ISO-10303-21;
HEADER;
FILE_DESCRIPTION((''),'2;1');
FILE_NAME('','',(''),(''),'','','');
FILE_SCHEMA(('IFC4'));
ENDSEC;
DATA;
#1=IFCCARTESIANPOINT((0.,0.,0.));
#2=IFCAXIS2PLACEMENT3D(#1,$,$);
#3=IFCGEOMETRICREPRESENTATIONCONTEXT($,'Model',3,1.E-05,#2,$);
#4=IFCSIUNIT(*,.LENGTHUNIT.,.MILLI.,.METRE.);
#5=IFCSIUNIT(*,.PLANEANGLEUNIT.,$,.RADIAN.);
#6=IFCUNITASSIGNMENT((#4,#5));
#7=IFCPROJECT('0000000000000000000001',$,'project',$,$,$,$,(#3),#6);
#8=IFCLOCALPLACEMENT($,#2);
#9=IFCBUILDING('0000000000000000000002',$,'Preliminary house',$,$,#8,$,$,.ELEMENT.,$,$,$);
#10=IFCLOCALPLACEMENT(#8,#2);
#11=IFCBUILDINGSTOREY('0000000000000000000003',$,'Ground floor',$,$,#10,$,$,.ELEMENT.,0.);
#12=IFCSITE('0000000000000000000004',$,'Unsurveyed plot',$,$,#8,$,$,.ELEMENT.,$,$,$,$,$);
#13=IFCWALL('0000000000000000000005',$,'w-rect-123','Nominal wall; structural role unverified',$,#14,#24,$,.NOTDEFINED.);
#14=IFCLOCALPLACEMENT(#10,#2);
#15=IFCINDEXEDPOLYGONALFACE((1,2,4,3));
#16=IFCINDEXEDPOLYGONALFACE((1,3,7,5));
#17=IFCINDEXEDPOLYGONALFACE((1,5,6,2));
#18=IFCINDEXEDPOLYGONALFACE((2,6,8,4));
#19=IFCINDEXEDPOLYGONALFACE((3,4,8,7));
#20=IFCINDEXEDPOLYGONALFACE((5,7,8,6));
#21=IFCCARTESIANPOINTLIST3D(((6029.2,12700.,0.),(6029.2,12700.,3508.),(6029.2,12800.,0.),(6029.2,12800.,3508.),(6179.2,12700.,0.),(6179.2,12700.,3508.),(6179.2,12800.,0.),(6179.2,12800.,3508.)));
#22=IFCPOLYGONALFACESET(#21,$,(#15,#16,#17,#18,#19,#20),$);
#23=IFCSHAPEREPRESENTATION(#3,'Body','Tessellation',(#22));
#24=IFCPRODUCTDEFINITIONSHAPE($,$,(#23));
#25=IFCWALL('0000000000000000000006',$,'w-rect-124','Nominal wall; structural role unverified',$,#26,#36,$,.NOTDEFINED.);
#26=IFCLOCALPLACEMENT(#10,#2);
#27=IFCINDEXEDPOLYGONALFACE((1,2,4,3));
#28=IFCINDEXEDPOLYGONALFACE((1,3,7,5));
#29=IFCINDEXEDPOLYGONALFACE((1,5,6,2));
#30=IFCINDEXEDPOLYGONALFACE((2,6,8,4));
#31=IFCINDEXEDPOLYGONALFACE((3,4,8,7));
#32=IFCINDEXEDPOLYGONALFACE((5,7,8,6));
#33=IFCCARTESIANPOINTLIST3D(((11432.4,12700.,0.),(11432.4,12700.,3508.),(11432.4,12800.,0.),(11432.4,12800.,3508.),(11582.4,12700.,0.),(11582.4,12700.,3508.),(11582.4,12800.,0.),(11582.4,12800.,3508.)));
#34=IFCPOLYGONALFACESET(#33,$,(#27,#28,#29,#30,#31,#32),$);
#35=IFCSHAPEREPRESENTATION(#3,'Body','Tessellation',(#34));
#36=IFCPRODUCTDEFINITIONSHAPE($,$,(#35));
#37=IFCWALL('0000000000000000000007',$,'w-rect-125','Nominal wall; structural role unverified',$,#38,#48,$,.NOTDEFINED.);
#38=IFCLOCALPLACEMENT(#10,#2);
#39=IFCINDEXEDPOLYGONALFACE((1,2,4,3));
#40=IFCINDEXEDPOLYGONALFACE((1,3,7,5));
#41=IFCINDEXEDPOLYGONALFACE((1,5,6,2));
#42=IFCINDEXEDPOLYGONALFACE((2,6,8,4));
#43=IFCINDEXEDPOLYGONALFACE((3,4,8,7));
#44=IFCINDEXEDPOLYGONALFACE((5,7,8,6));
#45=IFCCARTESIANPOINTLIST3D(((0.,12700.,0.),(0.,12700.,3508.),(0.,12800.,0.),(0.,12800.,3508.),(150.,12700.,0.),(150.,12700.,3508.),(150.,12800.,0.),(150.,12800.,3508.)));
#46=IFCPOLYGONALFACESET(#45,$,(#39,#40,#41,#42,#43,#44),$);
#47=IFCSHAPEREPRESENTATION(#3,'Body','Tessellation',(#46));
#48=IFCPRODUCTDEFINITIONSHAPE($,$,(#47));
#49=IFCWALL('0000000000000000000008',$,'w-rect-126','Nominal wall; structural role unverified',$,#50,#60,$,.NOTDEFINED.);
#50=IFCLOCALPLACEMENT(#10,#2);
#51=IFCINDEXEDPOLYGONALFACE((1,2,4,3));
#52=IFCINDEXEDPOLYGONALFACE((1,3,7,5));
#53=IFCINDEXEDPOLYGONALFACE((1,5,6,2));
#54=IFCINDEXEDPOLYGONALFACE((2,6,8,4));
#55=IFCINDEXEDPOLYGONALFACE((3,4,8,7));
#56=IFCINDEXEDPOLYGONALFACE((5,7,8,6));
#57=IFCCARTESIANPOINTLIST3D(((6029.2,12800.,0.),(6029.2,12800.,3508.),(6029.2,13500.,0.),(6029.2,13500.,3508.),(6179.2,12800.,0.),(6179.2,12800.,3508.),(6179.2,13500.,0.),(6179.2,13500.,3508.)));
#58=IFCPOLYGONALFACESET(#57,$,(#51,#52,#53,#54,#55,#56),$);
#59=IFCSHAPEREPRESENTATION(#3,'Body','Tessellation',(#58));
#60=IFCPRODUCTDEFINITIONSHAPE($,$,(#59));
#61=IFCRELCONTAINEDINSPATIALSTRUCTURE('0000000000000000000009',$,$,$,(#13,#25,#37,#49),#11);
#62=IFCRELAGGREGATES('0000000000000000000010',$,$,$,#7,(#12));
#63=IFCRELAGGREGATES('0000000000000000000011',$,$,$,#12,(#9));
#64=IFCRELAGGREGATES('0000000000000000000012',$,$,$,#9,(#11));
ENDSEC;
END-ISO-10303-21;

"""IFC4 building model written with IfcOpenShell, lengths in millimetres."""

from ifc_helpers import new_model, si_unit, origin, place, context, project, spatial, polyline, outline, extrude, element, save


model = new_model("IFC4")

# Units and contexts
model_context = context("Model", 3, precision=1e-05, world=origin())
ifc_project = project(units=[si_unit("LENGTHUNIT", "METRE", prefix="MILLI"), si_unit("PLANEANGLEUNIT", "RADIAN")], contexts=[model_context])

# Site, building, storey
placement_1 = place(None, origin())
site = spatial("IfcSite", under=ifc_project, at=placement_1, Name="Unsurveyed plot", CompositionType="ELEMENT")
building = spatial("IfcBuilding", under=site, at=placement_1, Name="Preliminary house", CompositionType="ELEMENT")
placement_2 = place(placement_1, origin())
storey = spatial("IfcBuildingStorey", under=building, at=placement_2, Name="Ground floor", CompositionType="ELEMENT", Elevation=0.0)

# Walls
element("IfcWall", 1, at=placement_2, inside=storey, Name="w-rect-123", Description="Nominal wall; structural role unverified", PredefinedType="NOTDEFINED", context=model_context, shape_type="SweptSolid", body=[
    extrude(outline(polyline([(6029.2, 12700.0), (6179.2, 12700.0), (6179.2, 12800.0), (6029.2, 12800.0), (6029.2, 12700.0)])), origin(), (0.0, 0.0, 1.0), 3508.0),
])
element("IfcWall", 2, at=placement_2, inside=storey, Name="w-rect-124", Description="Nominal wall; structural role unverified", PredefinedType="NOTDEFINED", context=model_context, shape_type="SweptSolid", body=[
    extrude(outline(polyline([(11432.4, 12700.0), (11582.4, 12700.0), (11582.4, 12800.0), (11432.4, 12800.0), (11432.4, 12700.0)])), origin(), (0.0, 0.0, 1.0), 3508.0),
])
element("IfcWall", 3, at=placement_2, inside=storey, Name="w-rect-125", Description="Nominal wall; structural role unverified", PredefinedType="NOTDEFINED", context=model_context, shape_type="SweptSolid", body=[
    extrude(outline(polyline([(0.0, 12700.0), (150.0, 12700.0), (150.0, 12800.0), (0.0, 12800.0), (0.0, 12700.0)])), origin(), (0.0, 0.0, 1.0), 3508.0),
])
element("IfcWall", 4, at=placement_2, inside=storey, Name="w-rect-126", Description="Nominal wall; structural role unverified", PredefinedType="NOTDEFINED", context=model_context, shape_type="SweptSolid", body=[
    extrude(outline(polyline([(6029.2, 12800.0), (6179.2, 12800.0), (6179.2, 13500.0), (6029.2, 13500.0), (6029.2, 12800.0)])), origin(), (0.0, 0.0, 1.0), 3508.0),
])

save(model, "model.ifc")
